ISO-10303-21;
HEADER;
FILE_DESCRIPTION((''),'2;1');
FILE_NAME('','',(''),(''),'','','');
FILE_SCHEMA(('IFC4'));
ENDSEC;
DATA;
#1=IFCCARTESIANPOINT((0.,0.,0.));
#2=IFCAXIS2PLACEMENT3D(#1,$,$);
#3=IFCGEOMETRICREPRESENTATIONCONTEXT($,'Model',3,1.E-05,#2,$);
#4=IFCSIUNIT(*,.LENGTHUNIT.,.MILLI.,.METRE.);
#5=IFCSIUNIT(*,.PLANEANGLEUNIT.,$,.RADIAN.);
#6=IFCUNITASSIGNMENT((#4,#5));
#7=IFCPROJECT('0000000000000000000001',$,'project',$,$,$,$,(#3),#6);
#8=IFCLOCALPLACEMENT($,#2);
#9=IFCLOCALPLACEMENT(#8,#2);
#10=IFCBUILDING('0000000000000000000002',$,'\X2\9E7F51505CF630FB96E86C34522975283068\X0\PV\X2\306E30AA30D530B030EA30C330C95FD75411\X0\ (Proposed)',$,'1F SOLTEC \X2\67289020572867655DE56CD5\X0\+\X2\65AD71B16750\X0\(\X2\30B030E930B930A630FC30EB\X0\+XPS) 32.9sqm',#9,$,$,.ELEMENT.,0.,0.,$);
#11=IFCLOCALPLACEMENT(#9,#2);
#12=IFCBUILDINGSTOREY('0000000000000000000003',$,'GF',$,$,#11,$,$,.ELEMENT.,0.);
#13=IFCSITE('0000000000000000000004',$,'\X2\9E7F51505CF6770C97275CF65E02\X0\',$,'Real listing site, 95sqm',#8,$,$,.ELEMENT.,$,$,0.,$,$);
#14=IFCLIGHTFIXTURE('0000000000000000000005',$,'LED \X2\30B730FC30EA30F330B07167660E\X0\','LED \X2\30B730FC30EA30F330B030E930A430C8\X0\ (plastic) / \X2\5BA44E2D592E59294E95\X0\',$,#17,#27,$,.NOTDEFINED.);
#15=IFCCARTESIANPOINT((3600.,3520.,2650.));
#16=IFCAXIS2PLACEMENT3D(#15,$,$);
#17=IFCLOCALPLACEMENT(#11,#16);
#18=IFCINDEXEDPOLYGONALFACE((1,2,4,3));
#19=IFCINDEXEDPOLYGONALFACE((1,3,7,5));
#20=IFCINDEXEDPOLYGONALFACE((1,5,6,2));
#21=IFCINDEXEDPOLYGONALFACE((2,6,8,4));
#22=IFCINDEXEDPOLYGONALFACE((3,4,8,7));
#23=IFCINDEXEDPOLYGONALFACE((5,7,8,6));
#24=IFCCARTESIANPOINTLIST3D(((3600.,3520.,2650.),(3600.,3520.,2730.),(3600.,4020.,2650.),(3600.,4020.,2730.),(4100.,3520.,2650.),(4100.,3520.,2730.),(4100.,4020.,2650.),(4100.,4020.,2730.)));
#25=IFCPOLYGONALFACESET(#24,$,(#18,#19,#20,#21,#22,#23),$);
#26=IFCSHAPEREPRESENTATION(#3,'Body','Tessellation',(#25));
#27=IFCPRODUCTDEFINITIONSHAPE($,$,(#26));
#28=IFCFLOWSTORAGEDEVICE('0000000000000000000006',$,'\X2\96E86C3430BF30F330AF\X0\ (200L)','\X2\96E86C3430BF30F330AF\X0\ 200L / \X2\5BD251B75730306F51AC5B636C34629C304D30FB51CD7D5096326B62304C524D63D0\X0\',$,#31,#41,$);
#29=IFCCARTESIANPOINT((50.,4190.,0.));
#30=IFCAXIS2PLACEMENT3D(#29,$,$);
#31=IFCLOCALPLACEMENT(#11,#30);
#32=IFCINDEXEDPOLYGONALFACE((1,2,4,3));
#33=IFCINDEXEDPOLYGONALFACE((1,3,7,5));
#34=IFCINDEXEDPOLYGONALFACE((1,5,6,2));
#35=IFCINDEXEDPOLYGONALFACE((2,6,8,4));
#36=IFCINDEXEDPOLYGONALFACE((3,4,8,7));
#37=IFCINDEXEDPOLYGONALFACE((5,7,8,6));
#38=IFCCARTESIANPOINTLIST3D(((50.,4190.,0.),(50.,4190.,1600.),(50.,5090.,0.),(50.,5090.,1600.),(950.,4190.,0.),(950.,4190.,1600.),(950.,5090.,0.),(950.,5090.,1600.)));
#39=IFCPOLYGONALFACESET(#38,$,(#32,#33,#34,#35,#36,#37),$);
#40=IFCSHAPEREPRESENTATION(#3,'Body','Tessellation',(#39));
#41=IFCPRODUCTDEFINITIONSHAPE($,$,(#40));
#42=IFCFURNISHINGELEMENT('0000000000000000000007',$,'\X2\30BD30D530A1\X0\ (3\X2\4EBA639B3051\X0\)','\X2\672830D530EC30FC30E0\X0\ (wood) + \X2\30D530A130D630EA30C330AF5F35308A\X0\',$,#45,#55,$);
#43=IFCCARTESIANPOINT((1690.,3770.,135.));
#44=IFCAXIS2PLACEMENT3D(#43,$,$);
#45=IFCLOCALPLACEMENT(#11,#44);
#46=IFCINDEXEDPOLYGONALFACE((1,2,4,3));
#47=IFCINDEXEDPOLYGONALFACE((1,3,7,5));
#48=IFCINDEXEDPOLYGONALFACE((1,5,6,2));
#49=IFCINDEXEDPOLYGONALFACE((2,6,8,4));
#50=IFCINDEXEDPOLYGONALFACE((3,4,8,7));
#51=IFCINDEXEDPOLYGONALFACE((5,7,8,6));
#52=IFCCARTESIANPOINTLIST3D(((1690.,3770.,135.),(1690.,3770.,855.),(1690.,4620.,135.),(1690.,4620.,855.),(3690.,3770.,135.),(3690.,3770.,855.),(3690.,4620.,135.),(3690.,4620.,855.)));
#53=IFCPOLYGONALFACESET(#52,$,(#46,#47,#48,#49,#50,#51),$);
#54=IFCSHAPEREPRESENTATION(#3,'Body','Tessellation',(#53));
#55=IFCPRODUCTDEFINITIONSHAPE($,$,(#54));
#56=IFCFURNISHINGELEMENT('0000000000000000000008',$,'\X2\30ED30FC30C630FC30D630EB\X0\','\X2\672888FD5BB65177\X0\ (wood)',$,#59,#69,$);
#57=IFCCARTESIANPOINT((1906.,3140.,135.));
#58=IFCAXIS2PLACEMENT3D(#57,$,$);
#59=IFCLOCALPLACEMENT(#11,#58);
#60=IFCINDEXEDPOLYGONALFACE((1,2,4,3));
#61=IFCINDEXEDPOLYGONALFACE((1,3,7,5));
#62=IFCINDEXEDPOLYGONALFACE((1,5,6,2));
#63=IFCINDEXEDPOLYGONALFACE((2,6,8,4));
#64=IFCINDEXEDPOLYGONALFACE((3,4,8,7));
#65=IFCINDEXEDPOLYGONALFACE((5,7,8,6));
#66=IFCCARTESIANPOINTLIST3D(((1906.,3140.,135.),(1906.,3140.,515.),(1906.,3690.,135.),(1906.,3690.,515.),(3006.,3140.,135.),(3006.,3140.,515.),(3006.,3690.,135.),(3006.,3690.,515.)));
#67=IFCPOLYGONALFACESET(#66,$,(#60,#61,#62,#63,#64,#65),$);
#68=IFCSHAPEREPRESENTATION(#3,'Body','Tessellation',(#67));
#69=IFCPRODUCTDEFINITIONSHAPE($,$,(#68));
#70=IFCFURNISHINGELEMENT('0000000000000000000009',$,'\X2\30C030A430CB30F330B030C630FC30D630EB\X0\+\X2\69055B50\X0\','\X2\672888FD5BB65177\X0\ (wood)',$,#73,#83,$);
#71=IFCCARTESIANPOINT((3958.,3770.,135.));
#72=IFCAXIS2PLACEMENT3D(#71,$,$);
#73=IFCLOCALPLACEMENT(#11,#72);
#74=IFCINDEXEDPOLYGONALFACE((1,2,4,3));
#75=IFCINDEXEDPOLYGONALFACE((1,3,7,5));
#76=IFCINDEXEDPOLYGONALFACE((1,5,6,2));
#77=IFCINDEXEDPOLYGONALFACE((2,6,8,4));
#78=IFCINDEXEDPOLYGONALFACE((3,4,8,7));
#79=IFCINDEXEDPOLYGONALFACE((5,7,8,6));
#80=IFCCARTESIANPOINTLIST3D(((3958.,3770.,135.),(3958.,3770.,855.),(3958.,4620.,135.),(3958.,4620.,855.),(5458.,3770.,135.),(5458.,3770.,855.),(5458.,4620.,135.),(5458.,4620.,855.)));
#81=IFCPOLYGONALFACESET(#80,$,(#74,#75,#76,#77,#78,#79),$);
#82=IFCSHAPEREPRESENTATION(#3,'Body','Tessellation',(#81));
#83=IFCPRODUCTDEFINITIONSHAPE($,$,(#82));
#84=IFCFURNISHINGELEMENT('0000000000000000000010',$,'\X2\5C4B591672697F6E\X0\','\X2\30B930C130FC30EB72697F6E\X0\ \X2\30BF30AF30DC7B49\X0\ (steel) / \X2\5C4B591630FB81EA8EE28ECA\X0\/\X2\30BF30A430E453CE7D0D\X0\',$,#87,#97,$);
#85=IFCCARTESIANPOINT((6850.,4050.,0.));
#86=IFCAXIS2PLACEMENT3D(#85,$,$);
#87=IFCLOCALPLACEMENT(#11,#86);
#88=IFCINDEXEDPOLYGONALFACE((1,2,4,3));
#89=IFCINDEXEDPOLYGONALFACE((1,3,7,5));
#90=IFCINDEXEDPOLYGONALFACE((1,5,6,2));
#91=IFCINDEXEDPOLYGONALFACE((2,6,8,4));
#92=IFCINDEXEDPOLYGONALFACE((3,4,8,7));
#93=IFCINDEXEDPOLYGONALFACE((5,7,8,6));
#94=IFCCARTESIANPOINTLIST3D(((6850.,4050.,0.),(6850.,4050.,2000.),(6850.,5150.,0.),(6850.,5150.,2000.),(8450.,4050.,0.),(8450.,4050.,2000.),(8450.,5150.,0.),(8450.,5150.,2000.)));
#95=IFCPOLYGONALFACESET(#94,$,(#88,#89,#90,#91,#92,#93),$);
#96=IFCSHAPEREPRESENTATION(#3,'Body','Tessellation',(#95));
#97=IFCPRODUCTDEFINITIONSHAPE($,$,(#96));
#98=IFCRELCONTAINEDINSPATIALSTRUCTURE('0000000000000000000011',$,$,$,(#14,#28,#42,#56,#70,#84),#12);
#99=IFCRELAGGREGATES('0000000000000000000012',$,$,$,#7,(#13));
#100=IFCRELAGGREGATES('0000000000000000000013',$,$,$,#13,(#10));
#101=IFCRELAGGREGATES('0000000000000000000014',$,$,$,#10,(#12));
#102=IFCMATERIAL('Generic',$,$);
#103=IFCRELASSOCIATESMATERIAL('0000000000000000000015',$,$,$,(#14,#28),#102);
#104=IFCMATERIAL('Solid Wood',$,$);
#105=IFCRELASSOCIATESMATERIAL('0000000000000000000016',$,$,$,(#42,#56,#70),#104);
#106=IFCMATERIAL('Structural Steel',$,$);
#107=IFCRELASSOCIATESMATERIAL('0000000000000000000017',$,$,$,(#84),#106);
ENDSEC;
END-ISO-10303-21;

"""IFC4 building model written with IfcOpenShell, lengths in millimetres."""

from ifc_helpers import new_model, si_unit, frame, frame_2d, origin, place, context, project, spatial, rectangle, extrude, material, element, save


model = new_model("IFC4")

# Units and contexts
model_context = context("Model", 3, precision=1e-05, world=origin())
ifc_project = project(units=[si_unit("LENGTHUNIT", "METRE", prefix="MILLI"), si_unit("PLANEANGLEUNIT", "RADIAN")], contexts=[model_context])

# Site, building, storey
site_placement = place(None, origin())
site = spatial("IfcSite", under=ifc_project, at=site_placement, Name="鹿児島県霧島市", ObjectType="Real listing site, 95sqm", CompositionType="ELEMENT", RefElevation=0.0)
building_placement = place(site_placement, origin())
building = spatial("IfcBuilding", under=site, at=building_placement, Name="鹿児島・雨水利用とPVのオフグリッド志向 (Proposed)", ObjectType="1F SOLTEC 木造在来工法+断熱材(グラスウール+XPS) 32.9sqm", CompositionType="ELEMENT", ElevationOfRefHeight=0.0, ElevationOfTerrain=0.0)
storey_placement = place(building_placement, origin())
storey = spatial("IfcBuildingStorey", under=building, at=storey_placement, Name="GF", CompositionType="ELEMENT", Elevation=0.0)

# Shared definitions
ifc_material_1 = material(Name="Solid Wood")

# Shared definitions
ifc_material_2 = material(Name="Structural Steel")

# Light fixture
ifc_material_3 = material(Name="Generic")
light_fixture_placement = place(storey_placement, frame((3600.0, 3520.0, 2650.0)))
element("IfcLightFixture", 1, at=light_fixture_placement, inside=storey, material=ifc_material_3, Name="LED シーリング照明", Description="LED シーリングライト (plastic) / 室中央天井", PredefinedType="NOTDEFINED", context=model_context, shape_type="SweptSolid", body=[
    extrude(rectangle(XDim=500.0, YDim=500.0, at=frame_2d((250.0, 250.0))), frame((3600.0, 3520.0, 2650.0)), (0.0, 0.0, 1.0), 80.0),
])

# Flow storage device
flow_storage_device_placement = place(storey_placement, frame((50.0, 4190.0, 0.0)))
element("IfcFlowStorageDevice", 2, at=flow_storage_device_placement, inside=storey, material=ifc_material_3, Name="雨水タンク (200L)", Description="雨水タンク 200L / 寒冷地は冬季水抜き・凍結防止が前提", context=model_context, shape_type="SweptSolid", body=[
    extrude(rectangle(XDim=900.0, YDim=900.0, at=frame_2d((450.0, 450.0))), frame((50.0, 4190.0, 0.0)), (0.0, 0.0, 1.0), 1600.0),
])

# Furnishing elements
furnishing_1_placement = place(storey_placement, frame((1690.0, 3770.0, 135.0)))
element("IfcFurnishingElement", 3, at=furnishing_1_placement, inside=storey, material=ifc_material_1, Name="ソファ (3人掛け)", Description="木フレーム (wood) + ファブリック張り", context=model_context, shape_type="SweptSolid", body=[
    extrude(rectangle(XDim=2000.0, YDim=850.0, at=frame_2d((1000.0, 425.0))), frame((1690.0, 3770.0, 135.0)), (0.0, 0.0, 1.0), 720.0),
])
furnishing_2_placement = place(storey_placement, frame((1906.0, 3140.0, 135.0)))
element("IfcFurnishingElement", 4, at=furnishing_2_placement, inside=storey, material=ifc_material_1, Name="ローテーブル", Description="木製家具 (wood)", context=model_context, shape_type="SweptSolid", body=[
    extrude(rectangle(XDim=1100.0, YDim=550.0, at=frame_2d((550.0, 275.0))), frame((1906.0, 3140.0, 135.0)), (0.0, 0.0, 1.0), 380.0),
])
furnishing_3_placement = place(storey_placement, frame((3958.0, 3770.0, 135.0)))
element("IfcFurnishingElement", 5, at=furnishing_3_placement, inside=storey, material=ifc_material_1, Name="ダイニングテーブル+椅子", Description="木製家具 (wood)", context=model_context, shape_type="SweptSolid", body=[
    extrude(rectangle(XDim=1500.0, YDim=850.0, at=frame_2d((750.0, 425.0))), frame((3958.0, 3770.0, 135.0)), (0.0, 0.0, 1.0), 720.0),
])
furnishing_4_placement = place(storey_placement, frame((6850.0, 4050.0, 0.0)))
element("IfcFurnishingElement", 6, at=furnishing_4_placement, inside=storey, material=ifc_material_2, Name="屋外物置", Description="スチール物置 タクボ等 (steel) / 屋外・自転車/タイヤ収納", context=model_context, shape_type="SweptSolid", body=[
    extrude(rectangle(XDim=1600.0, YDim=1100.0, at=frame_2d((800.0, 550.0))), frame((6850.0, 4050.0, 0.0)), (0.0, 0.0, 1.0), 2000.0),
])

save(model, "model.ifc")
